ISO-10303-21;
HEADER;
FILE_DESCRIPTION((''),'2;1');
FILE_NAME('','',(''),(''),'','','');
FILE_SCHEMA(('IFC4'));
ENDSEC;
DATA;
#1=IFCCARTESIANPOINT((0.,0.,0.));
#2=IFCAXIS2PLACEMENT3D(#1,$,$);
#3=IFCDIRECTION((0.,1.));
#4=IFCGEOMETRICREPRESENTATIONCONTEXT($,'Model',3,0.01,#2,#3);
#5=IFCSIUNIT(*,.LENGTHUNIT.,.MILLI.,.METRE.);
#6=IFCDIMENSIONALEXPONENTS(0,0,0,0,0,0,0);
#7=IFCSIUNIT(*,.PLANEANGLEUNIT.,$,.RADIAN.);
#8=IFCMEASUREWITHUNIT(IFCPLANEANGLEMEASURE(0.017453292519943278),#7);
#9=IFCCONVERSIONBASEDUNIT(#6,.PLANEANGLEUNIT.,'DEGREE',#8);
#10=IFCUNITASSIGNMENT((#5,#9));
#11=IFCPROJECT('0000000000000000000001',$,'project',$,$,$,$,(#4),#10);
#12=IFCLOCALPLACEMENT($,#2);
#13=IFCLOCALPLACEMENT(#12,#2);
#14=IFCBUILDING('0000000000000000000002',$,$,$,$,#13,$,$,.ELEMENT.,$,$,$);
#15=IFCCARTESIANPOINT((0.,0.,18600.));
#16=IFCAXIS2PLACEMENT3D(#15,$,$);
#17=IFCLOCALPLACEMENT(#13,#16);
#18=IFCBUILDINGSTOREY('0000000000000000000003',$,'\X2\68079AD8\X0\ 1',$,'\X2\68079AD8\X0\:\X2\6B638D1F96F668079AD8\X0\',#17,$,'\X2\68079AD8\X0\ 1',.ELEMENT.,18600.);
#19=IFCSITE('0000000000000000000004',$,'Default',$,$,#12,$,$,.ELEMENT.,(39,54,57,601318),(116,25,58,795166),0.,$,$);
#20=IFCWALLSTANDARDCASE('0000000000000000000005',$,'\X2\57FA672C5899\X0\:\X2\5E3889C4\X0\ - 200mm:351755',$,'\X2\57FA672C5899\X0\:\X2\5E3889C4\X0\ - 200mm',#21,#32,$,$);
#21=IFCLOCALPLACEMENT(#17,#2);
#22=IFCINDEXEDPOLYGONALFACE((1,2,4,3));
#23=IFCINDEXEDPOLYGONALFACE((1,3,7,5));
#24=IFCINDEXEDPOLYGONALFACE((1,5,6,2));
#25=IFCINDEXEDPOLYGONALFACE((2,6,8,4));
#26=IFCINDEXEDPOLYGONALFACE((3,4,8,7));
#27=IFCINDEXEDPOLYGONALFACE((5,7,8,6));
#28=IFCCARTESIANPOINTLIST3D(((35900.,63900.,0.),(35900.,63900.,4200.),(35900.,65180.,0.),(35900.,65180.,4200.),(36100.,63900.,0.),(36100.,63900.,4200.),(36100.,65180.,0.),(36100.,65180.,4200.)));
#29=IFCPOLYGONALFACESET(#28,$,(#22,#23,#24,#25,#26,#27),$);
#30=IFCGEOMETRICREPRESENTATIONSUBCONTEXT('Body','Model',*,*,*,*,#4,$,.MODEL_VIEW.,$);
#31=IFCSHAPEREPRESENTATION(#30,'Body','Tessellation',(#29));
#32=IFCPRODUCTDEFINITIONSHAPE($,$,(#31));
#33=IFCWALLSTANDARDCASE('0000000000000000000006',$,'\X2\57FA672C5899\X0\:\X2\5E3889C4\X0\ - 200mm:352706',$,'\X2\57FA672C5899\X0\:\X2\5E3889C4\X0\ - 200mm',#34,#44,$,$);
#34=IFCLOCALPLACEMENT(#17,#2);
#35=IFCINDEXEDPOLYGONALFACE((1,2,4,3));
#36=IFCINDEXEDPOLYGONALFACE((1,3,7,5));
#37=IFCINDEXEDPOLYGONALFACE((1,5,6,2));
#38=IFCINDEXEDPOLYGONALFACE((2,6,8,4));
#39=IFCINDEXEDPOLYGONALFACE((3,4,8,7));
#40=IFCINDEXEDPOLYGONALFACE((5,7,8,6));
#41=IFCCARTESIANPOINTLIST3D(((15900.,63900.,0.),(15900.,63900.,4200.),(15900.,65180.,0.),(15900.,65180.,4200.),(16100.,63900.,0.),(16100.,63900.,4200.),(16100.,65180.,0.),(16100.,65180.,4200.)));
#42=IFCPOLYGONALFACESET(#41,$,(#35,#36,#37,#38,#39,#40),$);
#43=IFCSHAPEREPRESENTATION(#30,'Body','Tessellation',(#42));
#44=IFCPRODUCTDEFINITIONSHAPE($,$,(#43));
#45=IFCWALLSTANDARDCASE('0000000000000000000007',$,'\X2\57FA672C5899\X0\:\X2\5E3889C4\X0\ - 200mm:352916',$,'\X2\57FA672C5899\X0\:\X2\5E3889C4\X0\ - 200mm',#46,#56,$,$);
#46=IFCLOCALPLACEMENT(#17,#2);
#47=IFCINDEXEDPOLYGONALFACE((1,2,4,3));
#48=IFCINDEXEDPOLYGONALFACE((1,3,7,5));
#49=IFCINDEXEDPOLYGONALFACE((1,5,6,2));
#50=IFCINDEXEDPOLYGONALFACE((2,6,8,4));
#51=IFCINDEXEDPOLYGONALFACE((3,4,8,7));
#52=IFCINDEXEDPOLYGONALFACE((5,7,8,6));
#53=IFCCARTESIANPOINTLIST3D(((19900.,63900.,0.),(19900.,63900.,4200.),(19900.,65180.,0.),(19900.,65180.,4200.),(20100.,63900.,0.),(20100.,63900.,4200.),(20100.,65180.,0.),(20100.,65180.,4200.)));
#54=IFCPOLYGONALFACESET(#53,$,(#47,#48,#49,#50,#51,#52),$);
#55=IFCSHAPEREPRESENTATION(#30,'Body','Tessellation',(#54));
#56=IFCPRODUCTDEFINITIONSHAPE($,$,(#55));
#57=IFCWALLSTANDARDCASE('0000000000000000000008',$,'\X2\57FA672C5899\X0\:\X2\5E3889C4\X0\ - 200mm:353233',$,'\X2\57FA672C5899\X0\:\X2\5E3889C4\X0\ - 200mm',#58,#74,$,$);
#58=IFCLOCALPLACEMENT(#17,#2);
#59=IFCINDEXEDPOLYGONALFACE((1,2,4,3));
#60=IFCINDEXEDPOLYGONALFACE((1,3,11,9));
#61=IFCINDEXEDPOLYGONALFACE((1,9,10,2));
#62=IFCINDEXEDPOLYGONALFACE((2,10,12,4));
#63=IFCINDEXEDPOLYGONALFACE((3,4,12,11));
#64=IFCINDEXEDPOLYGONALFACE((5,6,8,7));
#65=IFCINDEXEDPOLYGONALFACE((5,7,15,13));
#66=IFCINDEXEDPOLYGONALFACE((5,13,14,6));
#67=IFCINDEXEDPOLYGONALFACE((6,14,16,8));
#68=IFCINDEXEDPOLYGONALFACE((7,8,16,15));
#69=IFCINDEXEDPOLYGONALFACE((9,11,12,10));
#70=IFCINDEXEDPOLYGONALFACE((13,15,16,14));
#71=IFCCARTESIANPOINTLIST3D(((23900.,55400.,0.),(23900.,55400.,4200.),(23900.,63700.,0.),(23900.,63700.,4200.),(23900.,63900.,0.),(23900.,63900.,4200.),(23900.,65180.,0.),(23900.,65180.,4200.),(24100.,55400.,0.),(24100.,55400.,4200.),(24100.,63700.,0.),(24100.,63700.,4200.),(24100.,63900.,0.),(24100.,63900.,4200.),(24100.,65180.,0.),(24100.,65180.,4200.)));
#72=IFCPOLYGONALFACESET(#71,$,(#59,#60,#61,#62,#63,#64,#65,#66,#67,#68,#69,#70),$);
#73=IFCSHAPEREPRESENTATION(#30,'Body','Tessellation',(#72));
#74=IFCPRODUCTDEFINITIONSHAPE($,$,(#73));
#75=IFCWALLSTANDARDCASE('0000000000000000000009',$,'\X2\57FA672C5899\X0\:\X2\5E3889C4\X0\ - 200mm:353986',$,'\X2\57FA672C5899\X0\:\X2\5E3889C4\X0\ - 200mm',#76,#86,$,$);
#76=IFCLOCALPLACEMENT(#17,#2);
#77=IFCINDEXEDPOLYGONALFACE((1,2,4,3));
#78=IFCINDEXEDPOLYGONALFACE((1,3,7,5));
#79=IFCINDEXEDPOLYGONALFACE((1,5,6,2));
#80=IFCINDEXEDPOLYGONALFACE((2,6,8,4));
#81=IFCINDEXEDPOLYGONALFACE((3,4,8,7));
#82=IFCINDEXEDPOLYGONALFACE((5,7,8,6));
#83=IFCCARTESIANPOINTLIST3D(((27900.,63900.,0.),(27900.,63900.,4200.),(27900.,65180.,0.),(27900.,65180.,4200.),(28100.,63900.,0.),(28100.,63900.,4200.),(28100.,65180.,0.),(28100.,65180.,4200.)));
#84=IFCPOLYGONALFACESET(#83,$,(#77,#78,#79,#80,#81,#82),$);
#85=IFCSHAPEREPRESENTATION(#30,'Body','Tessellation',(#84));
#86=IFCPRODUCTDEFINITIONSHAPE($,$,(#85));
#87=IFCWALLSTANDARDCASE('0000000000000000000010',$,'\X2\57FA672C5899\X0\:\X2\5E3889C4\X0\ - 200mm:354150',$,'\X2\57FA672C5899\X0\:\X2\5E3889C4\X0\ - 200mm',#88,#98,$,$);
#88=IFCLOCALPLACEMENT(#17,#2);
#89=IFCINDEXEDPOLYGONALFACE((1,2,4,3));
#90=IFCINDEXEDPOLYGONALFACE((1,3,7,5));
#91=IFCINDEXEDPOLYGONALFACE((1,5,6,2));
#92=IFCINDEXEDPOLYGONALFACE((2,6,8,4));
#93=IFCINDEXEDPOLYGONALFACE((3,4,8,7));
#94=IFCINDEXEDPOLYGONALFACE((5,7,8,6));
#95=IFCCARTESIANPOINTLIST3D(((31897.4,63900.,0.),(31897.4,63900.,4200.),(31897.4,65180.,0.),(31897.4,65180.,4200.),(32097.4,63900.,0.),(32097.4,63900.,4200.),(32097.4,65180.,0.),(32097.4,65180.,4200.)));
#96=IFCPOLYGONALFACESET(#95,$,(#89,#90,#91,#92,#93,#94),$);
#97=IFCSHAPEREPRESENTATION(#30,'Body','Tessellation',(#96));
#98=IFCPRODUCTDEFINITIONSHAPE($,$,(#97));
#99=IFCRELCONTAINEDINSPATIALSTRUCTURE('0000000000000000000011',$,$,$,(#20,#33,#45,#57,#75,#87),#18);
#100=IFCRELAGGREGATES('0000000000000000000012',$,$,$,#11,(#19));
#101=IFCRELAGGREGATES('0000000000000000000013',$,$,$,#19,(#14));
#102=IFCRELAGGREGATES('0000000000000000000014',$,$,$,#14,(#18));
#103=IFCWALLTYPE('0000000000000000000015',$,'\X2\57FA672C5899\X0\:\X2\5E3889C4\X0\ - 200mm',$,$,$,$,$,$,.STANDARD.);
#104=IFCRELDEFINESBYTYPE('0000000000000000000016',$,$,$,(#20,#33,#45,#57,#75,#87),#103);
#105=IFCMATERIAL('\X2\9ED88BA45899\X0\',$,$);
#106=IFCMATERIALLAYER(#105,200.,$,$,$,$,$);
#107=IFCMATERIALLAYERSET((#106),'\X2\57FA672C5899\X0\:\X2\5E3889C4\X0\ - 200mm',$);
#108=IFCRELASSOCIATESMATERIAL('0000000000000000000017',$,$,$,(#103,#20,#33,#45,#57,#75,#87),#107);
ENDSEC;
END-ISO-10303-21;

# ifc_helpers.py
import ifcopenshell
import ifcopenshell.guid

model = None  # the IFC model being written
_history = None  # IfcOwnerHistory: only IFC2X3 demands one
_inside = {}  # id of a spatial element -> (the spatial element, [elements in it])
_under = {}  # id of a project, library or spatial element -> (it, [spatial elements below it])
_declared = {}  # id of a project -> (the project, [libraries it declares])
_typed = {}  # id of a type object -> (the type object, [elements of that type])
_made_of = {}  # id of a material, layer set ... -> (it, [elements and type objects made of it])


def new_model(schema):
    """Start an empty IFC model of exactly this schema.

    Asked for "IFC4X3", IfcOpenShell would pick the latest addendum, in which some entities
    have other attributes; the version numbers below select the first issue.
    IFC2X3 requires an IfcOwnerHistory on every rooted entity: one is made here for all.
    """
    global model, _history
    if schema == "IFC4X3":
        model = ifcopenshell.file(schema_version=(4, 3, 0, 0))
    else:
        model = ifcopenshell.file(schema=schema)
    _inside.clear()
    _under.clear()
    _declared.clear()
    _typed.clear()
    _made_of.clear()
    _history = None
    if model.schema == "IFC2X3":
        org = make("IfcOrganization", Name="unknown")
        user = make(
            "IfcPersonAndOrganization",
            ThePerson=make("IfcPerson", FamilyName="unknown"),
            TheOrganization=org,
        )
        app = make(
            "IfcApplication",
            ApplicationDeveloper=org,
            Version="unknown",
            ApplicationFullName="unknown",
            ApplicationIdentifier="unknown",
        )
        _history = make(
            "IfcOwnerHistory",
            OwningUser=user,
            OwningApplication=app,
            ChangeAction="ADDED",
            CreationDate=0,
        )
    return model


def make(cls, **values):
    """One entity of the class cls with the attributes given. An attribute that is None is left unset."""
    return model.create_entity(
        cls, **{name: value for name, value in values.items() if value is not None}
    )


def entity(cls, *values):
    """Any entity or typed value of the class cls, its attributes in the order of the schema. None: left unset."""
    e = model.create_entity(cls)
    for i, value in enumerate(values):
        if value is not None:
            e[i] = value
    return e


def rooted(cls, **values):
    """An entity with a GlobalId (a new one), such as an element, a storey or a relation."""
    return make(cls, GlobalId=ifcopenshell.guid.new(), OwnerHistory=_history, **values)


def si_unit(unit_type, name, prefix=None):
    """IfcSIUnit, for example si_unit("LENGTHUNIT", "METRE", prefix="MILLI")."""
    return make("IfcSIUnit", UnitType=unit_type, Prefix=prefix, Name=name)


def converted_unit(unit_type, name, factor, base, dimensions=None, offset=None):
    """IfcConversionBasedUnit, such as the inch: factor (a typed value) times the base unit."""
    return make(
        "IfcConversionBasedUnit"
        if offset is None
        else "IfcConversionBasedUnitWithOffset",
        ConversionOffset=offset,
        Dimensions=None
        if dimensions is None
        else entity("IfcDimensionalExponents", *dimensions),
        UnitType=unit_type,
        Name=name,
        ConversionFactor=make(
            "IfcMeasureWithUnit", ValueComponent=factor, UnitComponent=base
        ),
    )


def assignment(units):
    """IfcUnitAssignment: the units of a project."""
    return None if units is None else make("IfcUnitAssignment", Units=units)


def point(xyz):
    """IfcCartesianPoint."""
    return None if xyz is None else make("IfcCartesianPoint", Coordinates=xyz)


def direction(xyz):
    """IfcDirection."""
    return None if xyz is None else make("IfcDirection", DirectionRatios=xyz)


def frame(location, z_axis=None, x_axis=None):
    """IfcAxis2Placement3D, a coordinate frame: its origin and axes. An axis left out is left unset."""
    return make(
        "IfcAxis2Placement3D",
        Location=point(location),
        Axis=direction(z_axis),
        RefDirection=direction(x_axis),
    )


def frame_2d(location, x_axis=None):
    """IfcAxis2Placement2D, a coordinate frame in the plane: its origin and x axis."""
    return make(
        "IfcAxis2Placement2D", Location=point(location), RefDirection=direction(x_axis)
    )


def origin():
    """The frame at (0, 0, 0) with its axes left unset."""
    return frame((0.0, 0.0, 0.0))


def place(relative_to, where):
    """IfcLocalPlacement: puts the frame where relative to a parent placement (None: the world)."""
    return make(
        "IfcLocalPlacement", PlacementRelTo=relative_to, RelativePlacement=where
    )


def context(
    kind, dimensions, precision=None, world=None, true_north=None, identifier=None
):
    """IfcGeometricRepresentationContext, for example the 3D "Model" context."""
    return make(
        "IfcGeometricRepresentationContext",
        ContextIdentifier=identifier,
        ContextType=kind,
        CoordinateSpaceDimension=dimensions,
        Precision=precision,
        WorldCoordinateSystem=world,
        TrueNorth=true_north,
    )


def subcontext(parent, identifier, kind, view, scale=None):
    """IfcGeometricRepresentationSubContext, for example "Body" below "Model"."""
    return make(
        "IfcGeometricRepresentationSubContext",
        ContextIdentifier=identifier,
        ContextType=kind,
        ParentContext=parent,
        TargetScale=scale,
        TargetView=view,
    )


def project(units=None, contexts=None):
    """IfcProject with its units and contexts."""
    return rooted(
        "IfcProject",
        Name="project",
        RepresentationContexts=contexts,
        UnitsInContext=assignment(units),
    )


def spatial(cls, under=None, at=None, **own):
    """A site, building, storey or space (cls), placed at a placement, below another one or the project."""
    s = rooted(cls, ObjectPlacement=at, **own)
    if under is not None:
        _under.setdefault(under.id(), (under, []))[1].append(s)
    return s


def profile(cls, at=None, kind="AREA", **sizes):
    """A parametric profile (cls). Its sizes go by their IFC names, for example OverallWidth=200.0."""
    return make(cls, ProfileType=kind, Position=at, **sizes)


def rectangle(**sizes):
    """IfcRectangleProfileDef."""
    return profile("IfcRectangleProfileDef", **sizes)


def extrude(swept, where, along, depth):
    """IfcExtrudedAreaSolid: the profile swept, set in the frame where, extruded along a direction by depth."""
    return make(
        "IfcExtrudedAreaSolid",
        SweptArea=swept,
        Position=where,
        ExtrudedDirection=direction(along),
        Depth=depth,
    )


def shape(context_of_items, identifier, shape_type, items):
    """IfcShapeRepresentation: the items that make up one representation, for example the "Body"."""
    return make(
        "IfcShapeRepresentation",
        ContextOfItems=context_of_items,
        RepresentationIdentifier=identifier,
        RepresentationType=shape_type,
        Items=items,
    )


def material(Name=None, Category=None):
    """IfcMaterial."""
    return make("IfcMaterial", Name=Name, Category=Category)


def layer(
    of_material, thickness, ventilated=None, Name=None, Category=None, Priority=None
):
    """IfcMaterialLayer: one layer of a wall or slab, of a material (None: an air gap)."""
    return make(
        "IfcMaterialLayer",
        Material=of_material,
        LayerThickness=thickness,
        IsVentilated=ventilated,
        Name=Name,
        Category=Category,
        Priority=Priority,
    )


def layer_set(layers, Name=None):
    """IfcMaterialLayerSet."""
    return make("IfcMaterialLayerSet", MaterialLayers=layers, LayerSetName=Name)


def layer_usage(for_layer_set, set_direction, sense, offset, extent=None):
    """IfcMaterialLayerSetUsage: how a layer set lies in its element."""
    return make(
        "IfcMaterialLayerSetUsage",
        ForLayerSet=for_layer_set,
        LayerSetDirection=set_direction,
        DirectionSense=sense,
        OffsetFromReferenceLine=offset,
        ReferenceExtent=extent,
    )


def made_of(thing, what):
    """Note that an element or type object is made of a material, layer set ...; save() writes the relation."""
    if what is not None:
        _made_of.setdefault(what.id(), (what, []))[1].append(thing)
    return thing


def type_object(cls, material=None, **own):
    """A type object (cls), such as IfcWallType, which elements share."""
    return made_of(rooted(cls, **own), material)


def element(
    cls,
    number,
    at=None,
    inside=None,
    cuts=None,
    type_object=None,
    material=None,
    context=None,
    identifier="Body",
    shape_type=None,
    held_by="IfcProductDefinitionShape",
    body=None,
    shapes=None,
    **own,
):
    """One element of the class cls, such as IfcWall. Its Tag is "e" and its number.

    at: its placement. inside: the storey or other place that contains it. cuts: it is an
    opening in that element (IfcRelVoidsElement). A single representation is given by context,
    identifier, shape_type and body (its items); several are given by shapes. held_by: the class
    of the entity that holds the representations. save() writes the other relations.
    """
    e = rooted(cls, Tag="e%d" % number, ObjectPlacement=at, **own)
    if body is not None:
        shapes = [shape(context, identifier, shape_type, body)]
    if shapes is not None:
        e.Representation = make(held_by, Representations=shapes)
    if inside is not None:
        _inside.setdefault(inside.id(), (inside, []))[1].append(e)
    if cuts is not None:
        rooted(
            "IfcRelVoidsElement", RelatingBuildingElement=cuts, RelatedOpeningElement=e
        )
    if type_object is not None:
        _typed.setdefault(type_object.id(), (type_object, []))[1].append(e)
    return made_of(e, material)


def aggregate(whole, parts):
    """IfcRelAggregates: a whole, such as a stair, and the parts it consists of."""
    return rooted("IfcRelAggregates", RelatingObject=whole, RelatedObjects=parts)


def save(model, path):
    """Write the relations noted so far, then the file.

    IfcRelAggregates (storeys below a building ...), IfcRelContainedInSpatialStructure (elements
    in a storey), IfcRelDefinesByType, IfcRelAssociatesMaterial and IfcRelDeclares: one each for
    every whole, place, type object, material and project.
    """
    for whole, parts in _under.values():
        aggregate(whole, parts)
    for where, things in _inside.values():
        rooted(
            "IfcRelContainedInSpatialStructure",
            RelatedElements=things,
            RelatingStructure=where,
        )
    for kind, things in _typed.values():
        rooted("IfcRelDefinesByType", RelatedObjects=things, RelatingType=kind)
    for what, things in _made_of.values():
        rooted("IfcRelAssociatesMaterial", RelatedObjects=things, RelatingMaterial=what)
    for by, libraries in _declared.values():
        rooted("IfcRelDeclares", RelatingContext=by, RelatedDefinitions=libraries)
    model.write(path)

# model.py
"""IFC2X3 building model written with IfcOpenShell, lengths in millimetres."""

from ifc_helpers import new_model, entity, si_unit, converted_unit, direction, frame, frame_2d, origin, place, context, subcontext, project, spatial, rectangle, extrude, material, layer, layer_set, layer_usage, type_object, element, save


model = new_model("IFC2X3")

# Units and contexts
model_context = context("Model", 3, precision=0.01, world=origin(), true_north=direction((0.0, 1.0)))
body_context = subcontext(model_context, "Body", "Model", "MODEL_VIEW")
ifc_project = project(units=[si_unit("LENGTHUNIT", "METRE", prefix="MILLI"), converted_unit("PLANEANGLEUNIT", "DEGREE", entity("IfcPlaneAngleMeasure", 0.017453292519943278), si_unit("PLANEANGLEUNIT", "RADIAN"), dimensions=[0, 0, 0, 0, 0, 0, 0])], contexts=[model_context])

# Site, building, storey
site_placement = place(None, origin())
site = spatial("IfcSite", under=ifc_project, at=site_placement, Name="Default", CompositionType="ELEMENT", RefLatitude=(39, 54, 57, 601318), RefLongitude=(116, 25, 58, 795166), RefElevation=0.0)
building_placement = place(site_placement, origin())
building = spatial("IfcBuilding", under=site, at=building_placement, CompositionType="ELEMENT")
storey_placement = place(building_placement, frame((0.0, 0.0, 18600.0)))
storey = spatial("IfcBuildingStorey", under=building, at=storey_placement, Name="标高 1", ObjectType="标高:正负零标高", LongName="标高 1", CompositionType="ELEMENT", Elevation=18600.0)

# Shared definitions
ifc_material_1 = material(Name="默认墙")
ifc_layer = layer(ifc_material_1, 200.0)
ifc_layer_set = layer_set([ifc_layer], Name="基本墙:常规 - 200mm")
wall_type = type_object("IfcWallType", Name="基本墙:常规 - 200mm", PredefinedType="STANDARD", material=ifc_layer_set)

# Walls
ifc_layer_usage_1 = layer_usage(ifc_layer_set, "AXIS2", "NEGATIVE", 100.0)
wall_1_placement = place(storey_placement, frame((36000.0, 63900.0, 0.0), z_axis=(0.0, 0.0, 1.0), x_axis=(0.0, 1.0, 0.0)))
element("IfcWallStandardCase", 1, at=wall_1_placement, inside=storey, type_object=wall_type, material=ifc_layer_usage_1, Name="基本墙:常规 - 200mm:351755", ObjectType="基本墙:常规 - 200mm", context=body_context, shape_type="SweptSolid", body=[
    extrude(rectangle(XDim=1280.0, YDim=200.0, at=frame_2d((640.0, 0.0), x_axis=(-1.0, 0.0))), origin(), (0.0, 0.0, 1.0), 4200.0),
])
ifc_layer_usage_2 = layer_usage(ifc_layer_set, "AXIS2", "NEGATIVE", 100.0)
wall_2_placement = place(storey_placement, frame((16000.0, 65180.0, 0.0), z_axis=(0.0, 0.0, 1.0), x_axis=(0.0, -1.0, 0.0)))
element("IfcWallStandardCase", 2, at=wall_2_placement, inside=storey, type_object=wall_type, material=ifc_layer_usage_2, Name="基本墙:常规 - 200mm:352706", ObjectType="基本墙:常规 - 200mm", context=body_context, shape_type="SweptSolid", body=[
    extrude(rectangle(XDim=1280.0, YDim=200.0, at=frame_2d((640.0, 0.0), x_axis=(-1.0, 0.0))), origin(), (0.0, 0.0, 1.0), 4200.0),
])
ifc_layer_usage_3 = layer_usage(ifc_layer_set, "AXIS2", "NEGATIVE", 100.0)
wall_3_placement = place(storey_placement, frame((20000.0, 63900.0, 0.0), z_axis=(0.0, 0.0, 1.0), x_axis=(0.0, 1.0, 0.0)))
element("IfcWallStandardCase", 3, at=wall_3_placement, inside=storey, type_object=wall_type, material=ifc_layer_usage_3, Name="基本墙:常规 - 200mm:352916", ObjectType="基本墙:常规 - 200mm", context=body_context, shape_type="SweptSolid", body=[
    extrude(rectangle(XDim=1280.0, YDim=200.0, at=frame_2d((640.0, 0.0), x_axis=(-1.0, 0.0))), origin(), (0.0, 0.0, 1.0), 4200.0),
])

# Wall, opening
ifc_layer_usage_4 = layer_usage(ifc_layer_set, "AXIS2", "NEGATIVE", 100.0)
wall_4_placement = place(storey_placement, frame((24000.0, 65180.0, 0.0), z_axis=(0.0, 0.0, 1.0), x_axis=(0.0, -1.0, 0.0)))
wall_4 = element("IfcWallStandardCase", 4, at=wall_4_placement, inside=storey, type_object=wall_type, material=ifc_layer_usage_4, Name="基本墙:常规 - 200mm:353233", ObjectType="基本墙:常规 - 200mm", context=body_context, shape_type="SweptSolid", body=[
    extrude(rectangle(XDim=9780.0, YDim=200.0, at=frame_2d((4890.0, 0.0), x_axis=(-1.0, 0.0))), origin(), (0.0, 0.0, 1.0), 4200.0),
])
opening_1_placement = place(storey_placement, frame((24000.0, 65180.0, 0.0), z_axis=(0.0, 0.0, 1.0), x_axis=(0.0, -1.0, 0.0)))
element("IfcOpeningElement", 5, at=opening_1_placement, cuts=wall_4, ObjectType="Opening", context=body_context, shape_type="SweptSolid", body=[
    extrude(rectangle(XDim=4200.0, YDim=200.0, at=frame_2d((0.0, 0.0), x_axis=(1.0, 0.0))), frame((1480.0, 0.0, 2100.0), z_axis=(-1.0, 0.0, 0.0), x_axis=(0.0, 0.0, 1.0)), (0.0, 0.0, 1.0), 200.0),
])

# Walls
ifc_layer_usage_5 = layer_usage(ifc_layer_set, "AXIS2", "NEGATIVE", 100.0)
wall_5_placement = place(storey_placement, frame((28000.0, 63900.0, 0.0), z_axis=(0.0, 0.0, 1.0), x_axis=(0.0, 1.0, 0.0)))
element("IfcWallStandardCase", 6, at=wall_5_placement, inside=storey, type_object=wall_type, material=ifc_layer_usage_5, Name="基本墙:常规 - 200mm:353986", ObjectType="基本墙:常规 - 200mm", context=body_context, shape_type="SweptSolid", body=[
    extrude(rectangle(XDim=1280.0, YDim=200.0, at=frame_2d((640.0, 0.0), x_axis=(-1.0, 0.0))), origin(), (0.0, 0.0, 1.0), 4200.0),
])
ifc_layer_usage_6 = layer_usage(ifc_layer_set, "AXIS2", "NEGATIVE", 100.0)
wall_6_placement = place(storey_placement, frame((31997.4, 63900.0, 0.0), z_axis=(0.0, 0.0, 1.0), x_axis=(0.0, 1.0, 0.0)))
element("IfcWallStandardCase", 7, at=wall_6_placement, inside=storey, type_object=wall_type, material=ifc_layer_usage_6, Name="基本墙:常规 - 200mm:354150", ObjectType="基本墙:常规 - 200mm", context=body_context, shape_type="SweptSolid", body=[
    extrude(rectangle(XDim=1280.0, YDim=200.0, at=frame_2d((640.0, 0.0), x_axis=(-1.0, 0.0))), origin(), (0.0, 0.0, 1.0), 4200.0),
])

save(model, "model.ifc")
